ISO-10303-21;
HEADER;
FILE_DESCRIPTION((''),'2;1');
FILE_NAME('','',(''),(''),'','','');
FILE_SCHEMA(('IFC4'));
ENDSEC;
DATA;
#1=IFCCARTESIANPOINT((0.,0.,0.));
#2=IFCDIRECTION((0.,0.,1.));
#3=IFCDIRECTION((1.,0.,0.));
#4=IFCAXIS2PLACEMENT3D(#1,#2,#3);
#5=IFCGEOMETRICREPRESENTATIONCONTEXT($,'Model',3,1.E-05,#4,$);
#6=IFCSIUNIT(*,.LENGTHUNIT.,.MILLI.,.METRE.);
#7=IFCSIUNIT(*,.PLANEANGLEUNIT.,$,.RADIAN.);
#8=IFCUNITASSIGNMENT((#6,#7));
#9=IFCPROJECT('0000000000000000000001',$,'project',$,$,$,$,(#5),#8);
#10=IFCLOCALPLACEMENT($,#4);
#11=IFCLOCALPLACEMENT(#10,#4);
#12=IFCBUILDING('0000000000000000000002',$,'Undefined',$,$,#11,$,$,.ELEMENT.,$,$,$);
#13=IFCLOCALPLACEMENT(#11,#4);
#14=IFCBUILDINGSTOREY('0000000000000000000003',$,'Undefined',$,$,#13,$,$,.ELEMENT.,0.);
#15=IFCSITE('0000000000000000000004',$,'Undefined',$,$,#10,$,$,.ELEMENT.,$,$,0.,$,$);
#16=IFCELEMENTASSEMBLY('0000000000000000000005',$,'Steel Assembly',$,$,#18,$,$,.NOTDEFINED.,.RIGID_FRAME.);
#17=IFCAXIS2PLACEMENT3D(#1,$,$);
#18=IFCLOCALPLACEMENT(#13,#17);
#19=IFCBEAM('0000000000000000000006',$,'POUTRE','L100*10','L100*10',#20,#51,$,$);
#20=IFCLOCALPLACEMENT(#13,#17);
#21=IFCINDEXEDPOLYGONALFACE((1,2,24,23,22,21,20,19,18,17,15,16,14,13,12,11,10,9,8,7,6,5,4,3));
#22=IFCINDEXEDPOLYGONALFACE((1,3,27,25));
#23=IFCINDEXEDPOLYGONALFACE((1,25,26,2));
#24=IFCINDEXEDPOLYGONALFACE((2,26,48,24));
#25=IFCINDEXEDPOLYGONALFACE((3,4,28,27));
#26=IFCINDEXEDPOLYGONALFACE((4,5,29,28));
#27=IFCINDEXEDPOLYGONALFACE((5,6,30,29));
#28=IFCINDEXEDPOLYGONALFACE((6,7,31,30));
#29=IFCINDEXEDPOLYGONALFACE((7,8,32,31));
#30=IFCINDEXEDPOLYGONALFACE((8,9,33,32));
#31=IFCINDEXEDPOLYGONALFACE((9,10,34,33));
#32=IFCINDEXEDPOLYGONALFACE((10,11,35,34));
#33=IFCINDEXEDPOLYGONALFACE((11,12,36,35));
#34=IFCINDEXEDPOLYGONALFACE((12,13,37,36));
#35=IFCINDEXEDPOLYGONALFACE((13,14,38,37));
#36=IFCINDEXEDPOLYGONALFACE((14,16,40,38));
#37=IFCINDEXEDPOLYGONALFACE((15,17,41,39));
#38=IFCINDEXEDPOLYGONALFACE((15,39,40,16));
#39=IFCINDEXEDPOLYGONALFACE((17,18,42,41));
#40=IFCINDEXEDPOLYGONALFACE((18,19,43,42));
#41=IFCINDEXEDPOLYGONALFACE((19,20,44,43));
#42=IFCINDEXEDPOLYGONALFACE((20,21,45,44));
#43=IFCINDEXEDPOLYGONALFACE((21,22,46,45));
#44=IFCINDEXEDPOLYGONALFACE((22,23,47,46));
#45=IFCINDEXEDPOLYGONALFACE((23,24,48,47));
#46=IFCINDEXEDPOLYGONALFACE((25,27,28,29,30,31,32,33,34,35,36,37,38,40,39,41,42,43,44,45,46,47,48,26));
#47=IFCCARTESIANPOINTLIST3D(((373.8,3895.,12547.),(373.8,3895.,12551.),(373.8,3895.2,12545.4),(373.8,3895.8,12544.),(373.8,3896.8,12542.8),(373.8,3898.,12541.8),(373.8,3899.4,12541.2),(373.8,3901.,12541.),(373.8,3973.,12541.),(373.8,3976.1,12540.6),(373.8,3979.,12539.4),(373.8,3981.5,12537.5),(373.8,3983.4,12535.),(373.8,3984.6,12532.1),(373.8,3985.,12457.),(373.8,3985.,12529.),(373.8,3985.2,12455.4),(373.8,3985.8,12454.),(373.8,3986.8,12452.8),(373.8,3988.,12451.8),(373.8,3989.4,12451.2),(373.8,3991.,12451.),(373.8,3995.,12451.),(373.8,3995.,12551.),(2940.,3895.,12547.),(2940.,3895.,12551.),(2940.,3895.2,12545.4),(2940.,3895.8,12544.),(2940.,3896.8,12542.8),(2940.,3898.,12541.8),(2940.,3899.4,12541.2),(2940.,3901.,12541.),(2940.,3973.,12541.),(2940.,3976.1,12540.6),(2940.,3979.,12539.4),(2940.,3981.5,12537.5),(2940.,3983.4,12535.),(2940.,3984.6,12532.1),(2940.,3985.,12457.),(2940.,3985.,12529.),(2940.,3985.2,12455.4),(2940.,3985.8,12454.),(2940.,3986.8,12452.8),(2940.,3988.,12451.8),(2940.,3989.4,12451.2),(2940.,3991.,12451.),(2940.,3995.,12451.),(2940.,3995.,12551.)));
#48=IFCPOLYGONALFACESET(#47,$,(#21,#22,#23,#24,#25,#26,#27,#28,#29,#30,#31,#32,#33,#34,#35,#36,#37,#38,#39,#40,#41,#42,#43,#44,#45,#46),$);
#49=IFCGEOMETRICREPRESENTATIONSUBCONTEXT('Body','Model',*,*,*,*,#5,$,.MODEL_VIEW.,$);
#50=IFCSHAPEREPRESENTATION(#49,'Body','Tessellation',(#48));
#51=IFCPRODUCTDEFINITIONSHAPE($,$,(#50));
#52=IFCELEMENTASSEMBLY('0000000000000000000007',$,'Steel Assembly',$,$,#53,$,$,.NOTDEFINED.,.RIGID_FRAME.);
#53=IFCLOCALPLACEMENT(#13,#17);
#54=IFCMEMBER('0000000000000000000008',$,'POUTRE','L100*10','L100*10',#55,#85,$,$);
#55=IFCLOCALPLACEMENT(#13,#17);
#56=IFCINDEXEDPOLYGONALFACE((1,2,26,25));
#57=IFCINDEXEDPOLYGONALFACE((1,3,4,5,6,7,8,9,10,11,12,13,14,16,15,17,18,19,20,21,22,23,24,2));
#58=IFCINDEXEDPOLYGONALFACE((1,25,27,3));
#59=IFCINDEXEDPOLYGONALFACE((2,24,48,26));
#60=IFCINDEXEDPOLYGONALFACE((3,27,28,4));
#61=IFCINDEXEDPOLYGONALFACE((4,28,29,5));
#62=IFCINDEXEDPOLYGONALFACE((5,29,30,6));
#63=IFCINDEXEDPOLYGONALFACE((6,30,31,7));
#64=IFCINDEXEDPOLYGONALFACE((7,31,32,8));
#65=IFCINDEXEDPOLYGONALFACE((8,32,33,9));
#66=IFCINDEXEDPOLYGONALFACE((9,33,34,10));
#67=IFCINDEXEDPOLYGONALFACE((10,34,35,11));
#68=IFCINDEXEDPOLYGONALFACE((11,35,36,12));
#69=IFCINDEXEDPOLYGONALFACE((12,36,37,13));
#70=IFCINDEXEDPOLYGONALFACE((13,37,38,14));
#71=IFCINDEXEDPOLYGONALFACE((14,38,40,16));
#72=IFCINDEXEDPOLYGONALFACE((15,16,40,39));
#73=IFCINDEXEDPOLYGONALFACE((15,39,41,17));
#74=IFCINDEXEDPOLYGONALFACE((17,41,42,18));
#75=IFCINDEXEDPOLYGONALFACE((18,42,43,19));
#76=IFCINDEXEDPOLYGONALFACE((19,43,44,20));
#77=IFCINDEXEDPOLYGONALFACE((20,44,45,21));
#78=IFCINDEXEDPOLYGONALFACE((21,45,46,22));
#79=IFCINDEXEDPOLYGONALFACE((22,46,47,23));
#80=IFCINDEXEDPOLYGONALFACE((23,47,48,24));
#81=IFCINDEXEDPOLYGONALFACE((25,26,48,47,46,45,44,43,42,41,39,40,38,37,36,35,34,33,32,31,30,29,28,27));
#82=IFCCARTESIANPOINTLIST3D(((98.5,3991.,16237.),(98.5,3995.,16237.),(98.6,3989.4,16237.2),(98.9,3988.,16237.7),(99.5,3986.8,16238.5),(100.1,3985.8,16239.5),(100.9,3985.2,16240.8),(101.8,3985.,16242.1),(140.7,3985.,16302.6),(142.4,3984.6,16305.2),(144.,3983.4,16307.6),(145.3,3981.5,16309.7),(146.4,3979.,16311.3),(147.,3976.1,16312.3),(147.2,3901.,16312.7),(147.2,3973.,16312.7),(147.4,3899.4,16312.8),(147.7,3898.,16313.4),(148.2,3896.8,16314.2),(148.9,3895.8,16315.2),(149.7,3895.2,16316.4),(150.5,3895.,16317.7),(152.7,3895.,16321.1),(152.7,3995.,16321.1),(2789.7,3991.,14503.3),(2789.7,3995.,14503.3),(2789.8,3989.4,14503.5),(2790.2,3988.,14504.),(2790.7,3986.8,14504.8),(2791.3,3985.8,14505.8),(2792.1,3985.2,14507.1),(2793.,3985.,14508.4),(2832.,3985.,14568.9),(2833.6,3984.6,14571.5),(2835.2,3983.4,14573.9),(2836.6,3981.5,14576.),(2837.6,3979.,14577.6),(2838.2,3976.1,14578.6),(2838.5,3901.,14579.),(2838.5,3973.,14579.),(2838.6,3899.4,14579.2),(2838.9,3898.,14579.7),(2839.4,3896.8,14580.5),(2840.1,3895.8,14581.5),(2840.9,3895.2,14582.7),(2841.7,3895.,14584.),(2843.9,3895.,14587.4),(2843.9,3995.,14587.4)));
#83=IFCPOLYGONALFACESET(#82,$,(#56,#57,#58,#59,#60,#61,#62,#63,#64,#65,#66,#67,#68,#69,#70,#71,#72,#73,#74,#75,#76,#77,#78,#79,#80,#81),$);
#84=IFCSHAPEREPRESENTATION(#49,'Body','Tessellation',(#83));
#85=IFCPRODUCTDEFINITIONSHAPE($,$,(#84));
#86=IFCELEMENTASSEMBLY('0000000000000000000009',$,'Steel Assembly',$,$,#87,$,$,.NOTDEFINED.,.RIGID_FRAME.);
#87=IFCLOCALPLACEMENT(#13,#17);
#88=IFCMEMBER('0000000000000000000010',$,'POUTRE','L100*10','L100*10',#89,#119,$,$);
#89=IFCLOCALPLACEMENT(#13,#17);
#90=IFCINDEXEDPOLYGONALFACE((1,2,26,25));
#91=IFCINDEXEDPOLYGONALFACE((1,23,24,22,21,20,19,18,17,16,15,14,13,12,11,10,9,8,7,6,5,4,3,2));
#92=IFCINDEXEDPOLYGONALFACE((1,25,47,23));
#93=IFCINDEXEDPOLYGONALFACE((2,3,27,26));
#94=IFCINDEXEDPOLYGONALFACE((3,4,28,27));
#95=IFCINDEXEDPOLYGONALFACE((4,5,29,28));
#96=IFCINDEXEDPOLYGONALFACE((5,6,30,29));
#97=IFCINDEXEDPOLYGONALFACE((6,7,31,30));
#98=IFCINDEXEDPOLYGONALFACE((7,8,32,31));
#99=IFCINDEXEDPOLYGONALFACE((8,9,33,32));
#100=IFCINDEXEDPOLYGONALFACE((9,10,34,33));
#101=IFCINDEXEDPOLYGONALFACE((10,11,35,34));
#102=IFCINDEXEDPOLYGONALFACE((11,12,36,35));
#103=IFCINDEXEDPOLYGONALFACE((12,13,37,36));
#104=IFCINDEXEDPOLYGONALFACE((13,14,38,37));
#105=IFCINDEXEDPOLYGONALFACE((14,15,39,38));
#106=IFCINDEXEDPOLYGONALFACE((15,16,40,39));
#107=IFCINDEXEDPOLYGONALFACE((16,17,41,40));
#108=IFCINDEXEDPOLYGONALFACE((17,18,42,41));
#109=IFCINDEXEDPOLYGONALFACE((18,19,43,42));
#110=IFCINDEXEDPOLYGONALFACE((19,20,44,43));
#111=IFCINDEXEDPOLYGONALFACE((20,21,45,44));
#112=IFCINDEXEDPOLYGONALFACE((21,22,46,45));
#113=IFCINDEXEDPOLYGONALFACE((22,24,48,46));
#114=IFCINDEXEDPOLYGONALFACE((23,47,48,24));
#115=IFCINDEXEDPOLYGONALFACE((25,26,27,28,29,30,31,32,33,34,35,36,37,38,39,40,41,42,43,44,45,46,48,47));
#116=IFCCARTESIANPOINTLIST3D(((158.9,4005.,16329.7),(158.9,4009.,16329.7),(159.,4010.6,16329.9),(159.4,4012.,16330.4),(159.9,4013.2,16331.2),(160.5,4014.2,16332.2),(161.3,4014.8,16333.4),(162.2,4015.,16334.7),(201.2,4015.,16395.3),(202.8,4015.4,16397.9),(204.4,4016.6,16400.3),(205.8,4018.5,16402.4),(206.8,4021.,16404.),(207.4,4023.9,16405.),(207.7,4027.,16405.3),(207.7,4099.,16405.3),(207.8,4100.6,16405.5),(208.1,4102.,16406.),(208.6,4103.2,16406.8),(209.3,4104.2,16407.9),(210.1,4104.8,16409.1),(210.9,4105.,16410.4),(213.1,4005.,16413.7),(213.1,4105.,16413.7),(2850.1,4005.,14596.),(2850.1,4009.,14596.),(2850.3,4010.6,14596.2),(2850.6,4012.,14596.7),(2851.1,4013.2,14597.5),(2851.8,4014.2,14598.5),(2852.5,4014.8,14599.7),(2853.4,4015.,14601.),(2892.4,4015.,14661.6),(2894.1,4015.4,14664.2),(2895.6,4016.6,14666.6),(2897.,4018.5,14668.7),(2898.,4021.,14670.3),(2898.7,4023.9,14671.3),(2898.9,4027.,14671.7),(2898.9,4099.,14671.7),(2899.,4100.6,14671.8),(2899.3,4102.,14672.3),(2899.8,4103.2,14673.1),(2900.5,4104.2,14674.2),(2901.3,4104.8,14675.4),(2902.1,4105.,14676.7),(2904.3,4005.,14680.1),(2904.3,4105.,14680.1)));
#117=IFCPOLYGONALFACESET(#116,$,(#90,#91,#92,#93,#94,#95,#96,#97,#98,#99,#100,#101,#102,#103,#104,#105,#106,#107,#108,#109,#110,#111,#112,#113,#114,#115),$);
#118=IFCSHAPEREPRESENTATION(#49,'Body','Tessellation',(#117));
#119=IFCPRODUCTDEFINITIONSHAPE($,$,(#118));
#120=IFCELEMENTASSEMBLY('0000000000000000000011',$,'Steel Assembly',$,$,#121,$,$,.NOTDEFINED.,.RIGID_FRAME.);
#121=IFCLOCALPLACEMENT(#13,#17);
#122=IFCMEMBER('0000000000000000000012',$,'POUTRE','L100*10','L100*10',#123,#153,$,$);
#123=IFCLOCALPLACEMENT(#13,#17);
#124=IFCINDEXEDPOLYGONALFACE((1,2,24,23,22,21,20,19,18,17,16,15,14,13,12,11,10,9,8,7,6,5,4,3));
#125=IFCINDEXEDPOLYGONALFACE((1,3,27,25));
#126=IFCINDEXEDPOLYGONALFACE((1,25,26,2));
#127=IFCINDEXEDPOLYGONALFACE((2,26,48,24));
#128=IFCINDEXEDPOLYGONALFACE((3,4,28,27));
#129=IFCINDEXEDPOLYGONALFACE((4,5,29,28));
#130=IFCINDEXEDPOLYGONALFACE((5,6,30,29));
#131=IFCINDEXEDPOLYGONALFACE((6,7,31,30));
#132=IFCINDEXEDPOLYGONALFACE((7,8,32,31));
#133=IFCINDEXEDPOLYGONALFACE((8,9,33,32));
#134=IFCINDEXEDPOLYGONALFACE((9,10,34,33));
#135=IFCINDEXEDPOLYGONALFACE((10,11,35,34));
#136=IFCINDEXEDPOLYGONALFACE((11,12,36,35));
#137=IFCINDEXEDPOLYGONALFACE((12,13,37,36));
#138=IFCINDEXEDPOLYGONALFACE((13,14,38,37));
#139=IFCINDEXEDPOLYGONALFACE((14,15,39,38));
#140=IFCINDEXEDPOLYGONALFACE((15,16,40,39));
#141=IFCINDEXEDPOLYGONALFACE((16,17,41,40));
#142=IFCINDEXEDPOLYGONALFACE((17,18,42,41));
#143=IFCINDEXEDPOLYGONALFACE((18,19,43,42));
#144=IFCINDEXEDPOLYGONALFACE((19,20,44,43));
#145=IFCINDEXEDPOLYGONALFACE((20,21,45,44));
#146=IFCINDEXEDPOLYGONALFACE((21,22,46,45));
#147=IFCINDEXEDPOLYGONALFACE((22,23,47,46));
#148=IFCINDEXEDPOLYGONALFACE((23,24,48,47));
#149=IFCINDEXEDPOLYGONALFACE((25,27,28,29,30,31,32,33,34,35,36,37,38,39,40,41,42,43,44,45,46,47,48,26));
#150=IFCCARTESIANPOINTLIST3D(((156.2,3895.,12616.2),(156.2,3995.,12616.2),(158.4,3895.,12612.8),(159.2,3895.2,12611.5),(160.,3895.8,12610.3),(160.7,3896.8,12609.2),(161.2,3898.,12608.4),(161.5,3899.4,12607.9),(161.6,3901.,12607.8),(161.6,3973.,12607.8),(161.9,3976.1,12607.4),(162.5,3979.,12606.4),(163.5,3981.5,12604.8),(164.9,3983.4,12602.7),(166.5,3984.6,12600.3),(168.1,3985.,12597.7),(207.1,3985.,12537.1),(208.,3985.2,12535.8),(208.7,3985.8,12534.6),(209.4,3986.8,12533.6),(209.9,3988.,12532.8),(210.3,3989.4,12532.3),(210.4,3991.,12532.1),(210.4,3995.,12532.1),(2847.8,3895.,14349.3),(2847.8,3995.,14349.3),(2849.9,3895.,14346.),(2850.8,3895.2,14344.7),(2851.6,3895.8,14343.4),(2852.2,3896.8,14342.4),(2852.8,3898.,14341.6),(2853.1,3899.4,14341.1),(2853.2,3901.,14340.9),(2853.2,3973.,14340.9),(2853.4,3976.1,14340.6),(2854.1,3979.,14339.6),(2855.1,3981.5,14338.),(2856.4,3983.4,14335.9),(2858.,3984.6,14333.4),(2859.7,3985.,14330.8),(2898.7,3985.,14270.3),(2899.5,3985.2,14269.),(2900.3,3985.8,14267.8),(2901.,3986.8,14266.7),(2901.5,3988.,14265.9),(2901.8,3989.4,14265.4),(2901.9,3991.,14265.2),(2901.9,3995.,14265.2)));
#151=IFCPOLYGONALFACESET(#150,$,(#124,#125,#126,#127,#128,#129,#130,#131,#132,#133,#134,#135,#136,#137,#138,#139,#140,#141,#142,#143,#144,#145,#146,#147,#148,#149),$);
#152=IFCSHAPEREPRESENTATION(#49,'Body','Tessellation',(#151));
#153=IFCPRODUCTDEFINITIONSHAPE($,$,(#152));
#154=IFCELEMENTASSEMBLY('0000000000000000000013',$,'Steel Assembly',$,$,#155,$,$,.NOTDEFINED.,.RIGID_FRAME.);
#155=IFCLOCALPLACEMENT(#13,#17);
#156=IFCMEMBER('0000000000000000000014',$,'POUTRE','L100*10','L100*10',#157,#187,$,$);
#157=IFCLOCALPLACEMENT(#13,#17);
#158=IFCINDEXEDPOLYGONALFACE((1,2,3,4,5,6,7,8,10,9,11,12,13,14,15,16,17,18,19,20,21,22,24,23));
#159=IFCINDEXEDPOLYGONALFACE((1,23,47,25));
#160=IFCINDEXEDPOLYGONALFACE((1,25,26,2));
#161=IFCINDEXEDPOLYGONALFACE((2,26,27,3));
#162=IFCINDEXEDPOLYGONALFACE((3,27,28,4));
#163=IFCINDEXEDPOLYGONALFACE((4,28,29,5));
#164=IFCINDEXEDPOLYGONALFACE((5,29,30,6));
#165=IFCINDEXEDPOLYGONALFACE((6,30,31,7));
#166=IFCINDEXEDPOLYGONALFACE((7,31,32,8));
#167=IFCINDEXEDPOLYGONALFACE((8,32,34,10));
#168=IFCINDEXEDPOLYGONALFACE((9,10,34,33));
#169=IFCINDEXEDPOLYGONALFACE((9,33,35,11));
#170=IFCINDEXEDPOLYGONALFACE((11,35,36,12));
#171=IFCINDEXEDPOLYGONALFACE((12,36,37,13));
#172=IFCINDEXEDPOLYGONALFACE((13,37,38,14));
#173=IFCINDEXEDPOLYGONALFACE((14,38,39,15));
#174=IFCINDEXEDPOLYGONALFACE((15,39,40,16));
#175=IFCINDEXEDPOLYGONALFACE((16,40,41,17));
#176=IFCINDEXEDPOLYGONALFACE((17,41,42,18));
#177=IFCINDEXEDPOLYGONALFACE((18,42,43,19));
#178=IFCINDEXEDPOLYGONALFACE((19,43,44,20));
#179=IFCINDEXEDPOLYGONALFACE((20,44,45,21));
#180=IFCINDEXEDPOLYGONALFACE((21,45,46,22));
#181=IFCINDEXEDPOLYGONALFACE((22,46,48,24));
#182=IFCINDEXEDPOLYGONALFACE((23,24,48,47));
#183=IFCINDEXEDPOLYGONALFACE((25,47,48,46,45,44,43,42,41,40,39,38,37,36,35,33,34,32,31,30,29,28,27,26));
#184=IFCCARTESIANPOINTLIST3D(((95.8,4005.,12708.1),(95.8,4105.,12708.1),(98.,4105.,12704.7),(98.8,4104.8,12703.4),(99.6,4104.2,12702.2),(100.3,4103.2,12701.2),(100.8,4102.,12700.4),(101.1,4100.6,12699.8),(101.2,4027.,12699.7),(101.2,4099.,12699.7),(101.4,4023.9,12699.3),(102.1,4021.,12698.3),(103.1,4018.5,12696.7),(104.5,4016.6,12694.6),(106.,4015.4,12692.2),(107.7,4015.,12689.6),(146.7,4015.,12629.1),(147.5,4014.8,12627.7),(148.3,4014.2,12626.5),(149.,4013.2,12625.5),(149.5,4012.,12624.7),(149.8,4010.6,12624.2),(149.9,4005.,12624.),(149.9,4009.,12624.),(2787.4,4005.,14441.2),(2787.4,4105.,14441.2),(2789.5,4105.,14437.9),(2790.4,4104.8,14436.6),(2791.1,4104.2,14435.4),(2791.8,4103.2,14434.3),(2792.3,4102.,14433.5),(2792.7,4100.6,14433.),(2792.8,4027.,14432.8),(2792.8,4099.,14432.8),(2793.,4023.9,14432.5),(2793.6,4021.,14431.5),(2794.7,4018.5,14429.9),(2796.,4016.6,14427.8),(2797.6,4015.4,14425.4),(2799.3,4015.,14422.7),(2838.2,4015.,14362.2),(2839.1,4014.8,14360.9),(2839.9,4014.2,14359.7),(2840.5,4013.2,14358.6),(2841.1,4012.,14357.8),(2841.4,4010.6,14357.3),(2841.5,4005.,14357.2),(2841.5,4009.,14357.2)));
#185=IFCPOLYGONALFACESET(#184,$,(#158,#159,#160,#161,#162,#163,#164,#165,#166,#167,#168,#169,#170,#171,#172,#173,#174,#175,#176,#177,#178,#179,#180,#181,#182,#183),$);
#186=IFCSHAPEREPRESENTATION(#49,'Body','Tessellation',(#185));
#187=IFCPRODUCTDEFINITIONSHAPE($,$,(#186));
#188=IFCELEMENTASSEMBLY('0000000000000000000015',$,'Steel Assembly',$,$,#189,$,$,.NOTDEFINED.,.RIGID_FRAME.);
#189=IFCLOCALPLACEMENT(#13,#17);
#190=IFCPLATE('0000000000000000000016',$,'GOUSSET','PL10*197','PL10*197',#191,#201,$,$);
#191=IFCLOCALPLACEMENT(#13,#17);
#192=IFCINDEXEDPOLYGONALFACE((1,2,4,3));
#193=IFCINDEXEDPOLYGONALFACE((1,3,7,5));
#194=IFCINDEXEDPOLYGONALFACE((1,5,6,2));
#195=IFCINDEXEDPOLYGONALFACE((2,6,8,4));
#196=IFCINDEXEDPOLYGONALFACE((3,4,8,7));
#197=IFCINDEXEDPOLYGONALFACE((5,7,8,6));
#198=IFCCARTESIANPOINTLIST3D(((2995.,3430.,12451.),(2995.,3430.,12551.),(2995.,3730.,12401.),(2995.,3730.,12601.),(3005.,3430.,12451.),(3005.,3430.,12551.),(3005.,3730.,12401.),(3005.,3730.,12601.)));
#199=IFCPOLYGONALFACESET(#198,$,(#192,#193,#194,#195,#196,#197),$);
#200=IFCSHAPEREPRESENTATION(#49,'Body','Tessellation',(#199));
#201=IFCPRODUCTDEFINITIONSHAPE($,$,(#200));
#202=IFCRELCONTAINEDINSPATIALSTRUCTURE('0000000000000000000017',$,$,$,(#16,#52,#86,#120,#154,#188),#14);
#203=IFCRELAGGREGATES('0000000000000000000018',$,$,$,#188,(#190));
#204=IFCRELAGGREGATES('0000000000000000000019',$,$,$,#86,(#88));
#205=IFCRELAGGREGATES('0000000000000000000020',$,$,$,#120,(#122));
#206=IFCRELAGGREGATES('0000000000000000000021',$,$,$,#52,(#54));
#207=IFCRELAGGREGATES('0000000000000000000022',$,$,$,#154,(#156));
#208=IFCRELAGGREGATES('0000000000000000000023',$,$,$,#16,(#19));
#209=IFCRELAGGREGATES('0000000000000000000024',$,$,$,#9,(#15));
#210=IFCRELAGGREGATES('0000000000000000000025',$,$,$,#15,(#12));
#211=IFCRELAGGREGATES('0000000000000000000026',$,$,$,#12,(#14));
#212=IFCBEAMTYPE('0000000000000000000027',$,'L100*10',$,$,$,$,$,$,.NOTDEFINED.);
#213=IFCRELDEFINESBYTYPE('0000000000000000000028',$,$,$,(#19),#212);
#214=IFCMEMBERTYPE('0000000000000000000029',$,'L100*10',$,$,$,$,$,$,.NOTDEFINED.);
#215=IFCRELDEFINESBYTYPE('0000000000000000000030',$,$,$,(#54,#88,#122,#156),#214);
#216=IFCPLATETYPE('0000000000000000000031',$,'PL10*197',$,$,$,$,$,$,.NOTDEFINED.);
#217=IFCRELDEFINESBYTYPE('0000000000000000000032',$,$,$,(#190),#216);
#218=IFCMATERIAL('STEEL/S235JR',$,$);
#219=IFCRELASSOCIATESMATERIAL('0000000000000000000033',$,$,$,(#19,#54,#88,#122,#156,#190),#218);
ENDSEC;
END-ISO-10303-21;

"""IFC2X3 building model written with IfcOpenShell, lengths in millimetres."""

from ifc_helpers import new_model, si_unit, frame, origin_with_axes, origin_2d_with_axis, place, context, subcontext, project, spatial, polyline, l_section, outline, extrude, material, type_object, element, aggregate, save


model = new_model("IFC2X3")

# Units and contexts
model_context = context("Model", 3, precision=1e-05, world=origin_with_axes())
body_context = subcontext(model_context, "Body", "Model", "MODEL_VIEW")
ifc_project = project(units=[si_unit("LENGTHUNIT", "METRE", prefix="MILLI"), si_unit("PLANEANGLEUNIT", "RADIAN")], contexts=[model_context])

# Site, building, storey
site_placement = place(None, origin_with_axes())
site = spatial("IfcSite", under=ifc_project, at=site_placement, Name="Undefined", CompositionType="ELEMENT", RefElevation=0.0)
building_placement = place(site_placement, origin_with_axes())
building = spatial("IfcBuilding", under=site, at=building_placement, Name="Undefined", CompositionType="ELEMENT")
storey_placement = place(building_placement, origin_with_axes())
storey = spatial("IfcBuildingStorey", under=building, at=storey_placement, Name="Undefined", CompositionType="ELEMENT", Elevation=0.0)

# Element assembly, beam
ifc_material_1 = material(Name="STEEL/S235JR")
beam_type = type_object("IfcBeamType", Name="L100*10", PredefinedType="NOTDEFINED")
assembly_1_placement = place(storey_placement, origin_with_axes())
assembly_1 = element("IfcElementAssembly", 1, at=assembly_1_placement, inside=storey, Name="Steel Assembly", AssemblyPlace="NOTDEFINED", PredefinedType="RIGID_FRAME")
beam_1_placement = place(assembly_1_placement, frame((373.8, 3945.0, 12501.0), z_axis=(0.0, -1.0, 0.0), x_axis=(1.0, 0.0, 0.0)))
beam_1 = element("IfcBeam", 2, at=beam_1_placement, type_object=beam_type, material=ifc_material_1, Name="POUTRE", Description="L100*10", ObjectType="L100*10", context=body_context, shape_type="SweptSolid", body=[
    extrude(l_section(Depth=100.0, Width=100.0, Thickness=10.0, FilletRadius=12.0, EdgeRadius=6.0, at=origin_2d_with_axis()), frame((2566.2, 0.0, 0.0), z_axis=(-1.0, 0.0, 0.0), x_axis=(0.0, -1.0, 0.0)), (0.0, 0.0, 1.0), 2566.2),
])

# Element assemblies, members
member_type = type_object("IfcMemberType", Name="L100*10", PredefinedType="NOTDEFINED")
assembly_2_placement = place(storey_placement, origin_with_axes())
assembly_2 = element("IfcElementAssembly", 3, at=assembly_2_placement, inside=storey, Name="Steel Assembly", AssemblyPlace="NOTDEFINED", PredefinedType="RIGID_FRAME")
member_1_placement = place(assembly_2_placement, frame((2816.8, 3945.0, 14545.4), z_axis=(-0.541558, 0.0, -0.840664), x_axis=(-0.840664, 0.0, 0.541558)))
member_1 = element("IfcMember", 4, at=member_1_placement, type_object=member_type, material=ifc_material_1, Name="POUTRE", Description="L100*10", ObjectType="L100*10", context=body_context, shape_type="SweptSolid", body=[
    extrude(l_section(Depth=100.0, Width=100.0, Thickness=10.0, FilletRadius=12.0, EdgeRadius=6.0, at=origin_2d_with_axis()), frame((3201.3, 0.0, 0.0), z_axis=(-1.0, 0.0, 0.0), x_axis=(0.0, -1.0, 0.0)), (0.0, 0.0, 1.0), 3201.3),
])
assembly_3_placement = place(storey_placement, origin_with_axes())
assembly_3 = element("IfcElementAssembly", 5, at=assembly_3_placement, inside=storey, Name="Steel Assembly", AssemblyPlace="NOTDEFINED", PredefinedType="RIGID_FRAME")
member_2_placement = place(assembly_3_placement, frame((2877.2, 4055.0, 14638.0), z_axis=(0.0, 1.0, 0.0), x_axis=(-0.840664, 0.0, 0.541558)))
member_2 = element("IfcMember", 6, at=member_2_placement, type_object=member_type, material=ifc_material_1, Name="POUTRE", Description="L100*10", ObjectType="L100*10", context=body_context, shape_type="SweptSolid", body=[
    extrude(l_section(Depth=100.0, Width=100.0, Thickness=10.0, FilletRadius=12.0, EdgeRadius=6.0, at=origin_2d_with_axis()), frame((3201.3, 0.0, 0.0), z_axis=(-1.0, 0.0, 0.0), x_axis=(0.0, -1.0, 0.0)), (0.0, 0.0, 1.0), 3201.3),
])
assembly_4_placement = place(storey_placement, origin_with_axes())
assembly_4 = element("IfcElementAssembly", 7, at=assembly_4_placement, inside=storey, Name="Steel Assembly", AssemblyPlace="NOTDEFINED", PredefinedType="RIGID_FRAME")
member_3_placement = place(assembly_4_placement, frame((183.3, 3945.0, 12574.1), z_axis=(0.0, -1.0, 0.0), x_axis=(0.84077, 0.0, 0.541392)))
member_3 = element("IfcMember", 8, at=member_3_placement, type_object=member_type, material=ifc_material_1, Name="POUTRE", Description="L100*10", ObjectType="L100*10", context=body_context, shape_type="SweptSolid", body=[
    extrude(l_section(Depth=100.0, Width=100.0, Thickness=10.0, FilletRadius=12.0, EdgeRadius=6.0, at=origin_2d_with_axis()), frame((3201.3, 0.0, 0.0), z_axis=(-1.0, 0.0, 0.0), x_axis=(0.0, -1.0, 0.0)), (0.0, 0.0, 1.0), 3201.3),
])
assembly_5_placement = place(storey_placement, origin_with_axes())
assembly_5 = element("IfcElementAssembly", 9, at=assembly_5_placement, inside=storey, Name="Steel Assembly", AssemblyPlace="NOTDEFINED", PredefinedType="RIGID_FRAME")
member_4_placement = place(assembly_5_placement, frame((122.8, 4055.0, 12666.0), z_axis=(0.541392, 0.0, -0.84077), x_axis=(0.84077, 0.0, 0.541392)))
member_4 = element("IfcMember", 10, at=member_4_placement, type_object=member_type, material=ifc_material_1, Name="POUTRE", Description="L100*10", ObjectType="L100*10", context=body_context, shape_type="SweptSolid", body=[
    extrude(l_section(Depth=100.0, Width=100.0, Thickness=10.0, FilletRadius=12.0, EdgeRadius=6.0, at=origin_2d_with_axis()), frame((3201.3, 0.0, 0.0), z_axis=(-1.0, 0.0, 0.0), x_axis=(0.0, -1.0, 0.0)), (0.0, 0.0, 1.0), 3201.3),
])

# Element assembly, plate
assembly_6_placement = place(storey_placement, origin_with_axes())
assembly_6 = element("IfcElementAssembly", 11, at=assembly_6_placement, inside=storey, Name="Steel Assembly", AssemblyPlace="NOTDEFINED", PredefinedType="RIGID_FRAME")
plate_type_1 = type_object("IfcPlateType", Name="PL10*197", PredefinedType="NOTDEFINED")
plate_1_placement = place(assembly_6_placement, frame((3000.0, 3730.0, 12601.0), z_axis=(-1.0, 0.0, 0.0), x_axis=(0.0, 0.0, -1.0)))
plate_1 = element("IfcPlate", 12, at=plate_1_placement, type_object=plate_type_1, material=ifc_material_1, Name="GOUSSET", Description="PL10*197", ObjectType="PL10*197", context=body_context, shape_type="SweptSolid", body=[
    extrude(outline(polyline([(0.0, 0.0), (200.0, 0.0), (150.0, 300.0), (50.0, 300.0), (0.0, 0.0)])), frame((0.0, 0.0, -5.0), z_axis=(0.0, 0.0, 1.0), x_axis=(1.0, 0.0, 0.0)), (0.0, 0.0, 1.0), 10.0),
])
aggregate(assembly_6, [plate_1])

aggregate(assembly_3, [member_2])

aggregate(assembly_4, [member_3])
aggregate(assembly_2, [member_1])
aggregate(assembly_5, [member_4])

aggregate(assembly_1, [beam_1])

save(model, "model.ifc")
